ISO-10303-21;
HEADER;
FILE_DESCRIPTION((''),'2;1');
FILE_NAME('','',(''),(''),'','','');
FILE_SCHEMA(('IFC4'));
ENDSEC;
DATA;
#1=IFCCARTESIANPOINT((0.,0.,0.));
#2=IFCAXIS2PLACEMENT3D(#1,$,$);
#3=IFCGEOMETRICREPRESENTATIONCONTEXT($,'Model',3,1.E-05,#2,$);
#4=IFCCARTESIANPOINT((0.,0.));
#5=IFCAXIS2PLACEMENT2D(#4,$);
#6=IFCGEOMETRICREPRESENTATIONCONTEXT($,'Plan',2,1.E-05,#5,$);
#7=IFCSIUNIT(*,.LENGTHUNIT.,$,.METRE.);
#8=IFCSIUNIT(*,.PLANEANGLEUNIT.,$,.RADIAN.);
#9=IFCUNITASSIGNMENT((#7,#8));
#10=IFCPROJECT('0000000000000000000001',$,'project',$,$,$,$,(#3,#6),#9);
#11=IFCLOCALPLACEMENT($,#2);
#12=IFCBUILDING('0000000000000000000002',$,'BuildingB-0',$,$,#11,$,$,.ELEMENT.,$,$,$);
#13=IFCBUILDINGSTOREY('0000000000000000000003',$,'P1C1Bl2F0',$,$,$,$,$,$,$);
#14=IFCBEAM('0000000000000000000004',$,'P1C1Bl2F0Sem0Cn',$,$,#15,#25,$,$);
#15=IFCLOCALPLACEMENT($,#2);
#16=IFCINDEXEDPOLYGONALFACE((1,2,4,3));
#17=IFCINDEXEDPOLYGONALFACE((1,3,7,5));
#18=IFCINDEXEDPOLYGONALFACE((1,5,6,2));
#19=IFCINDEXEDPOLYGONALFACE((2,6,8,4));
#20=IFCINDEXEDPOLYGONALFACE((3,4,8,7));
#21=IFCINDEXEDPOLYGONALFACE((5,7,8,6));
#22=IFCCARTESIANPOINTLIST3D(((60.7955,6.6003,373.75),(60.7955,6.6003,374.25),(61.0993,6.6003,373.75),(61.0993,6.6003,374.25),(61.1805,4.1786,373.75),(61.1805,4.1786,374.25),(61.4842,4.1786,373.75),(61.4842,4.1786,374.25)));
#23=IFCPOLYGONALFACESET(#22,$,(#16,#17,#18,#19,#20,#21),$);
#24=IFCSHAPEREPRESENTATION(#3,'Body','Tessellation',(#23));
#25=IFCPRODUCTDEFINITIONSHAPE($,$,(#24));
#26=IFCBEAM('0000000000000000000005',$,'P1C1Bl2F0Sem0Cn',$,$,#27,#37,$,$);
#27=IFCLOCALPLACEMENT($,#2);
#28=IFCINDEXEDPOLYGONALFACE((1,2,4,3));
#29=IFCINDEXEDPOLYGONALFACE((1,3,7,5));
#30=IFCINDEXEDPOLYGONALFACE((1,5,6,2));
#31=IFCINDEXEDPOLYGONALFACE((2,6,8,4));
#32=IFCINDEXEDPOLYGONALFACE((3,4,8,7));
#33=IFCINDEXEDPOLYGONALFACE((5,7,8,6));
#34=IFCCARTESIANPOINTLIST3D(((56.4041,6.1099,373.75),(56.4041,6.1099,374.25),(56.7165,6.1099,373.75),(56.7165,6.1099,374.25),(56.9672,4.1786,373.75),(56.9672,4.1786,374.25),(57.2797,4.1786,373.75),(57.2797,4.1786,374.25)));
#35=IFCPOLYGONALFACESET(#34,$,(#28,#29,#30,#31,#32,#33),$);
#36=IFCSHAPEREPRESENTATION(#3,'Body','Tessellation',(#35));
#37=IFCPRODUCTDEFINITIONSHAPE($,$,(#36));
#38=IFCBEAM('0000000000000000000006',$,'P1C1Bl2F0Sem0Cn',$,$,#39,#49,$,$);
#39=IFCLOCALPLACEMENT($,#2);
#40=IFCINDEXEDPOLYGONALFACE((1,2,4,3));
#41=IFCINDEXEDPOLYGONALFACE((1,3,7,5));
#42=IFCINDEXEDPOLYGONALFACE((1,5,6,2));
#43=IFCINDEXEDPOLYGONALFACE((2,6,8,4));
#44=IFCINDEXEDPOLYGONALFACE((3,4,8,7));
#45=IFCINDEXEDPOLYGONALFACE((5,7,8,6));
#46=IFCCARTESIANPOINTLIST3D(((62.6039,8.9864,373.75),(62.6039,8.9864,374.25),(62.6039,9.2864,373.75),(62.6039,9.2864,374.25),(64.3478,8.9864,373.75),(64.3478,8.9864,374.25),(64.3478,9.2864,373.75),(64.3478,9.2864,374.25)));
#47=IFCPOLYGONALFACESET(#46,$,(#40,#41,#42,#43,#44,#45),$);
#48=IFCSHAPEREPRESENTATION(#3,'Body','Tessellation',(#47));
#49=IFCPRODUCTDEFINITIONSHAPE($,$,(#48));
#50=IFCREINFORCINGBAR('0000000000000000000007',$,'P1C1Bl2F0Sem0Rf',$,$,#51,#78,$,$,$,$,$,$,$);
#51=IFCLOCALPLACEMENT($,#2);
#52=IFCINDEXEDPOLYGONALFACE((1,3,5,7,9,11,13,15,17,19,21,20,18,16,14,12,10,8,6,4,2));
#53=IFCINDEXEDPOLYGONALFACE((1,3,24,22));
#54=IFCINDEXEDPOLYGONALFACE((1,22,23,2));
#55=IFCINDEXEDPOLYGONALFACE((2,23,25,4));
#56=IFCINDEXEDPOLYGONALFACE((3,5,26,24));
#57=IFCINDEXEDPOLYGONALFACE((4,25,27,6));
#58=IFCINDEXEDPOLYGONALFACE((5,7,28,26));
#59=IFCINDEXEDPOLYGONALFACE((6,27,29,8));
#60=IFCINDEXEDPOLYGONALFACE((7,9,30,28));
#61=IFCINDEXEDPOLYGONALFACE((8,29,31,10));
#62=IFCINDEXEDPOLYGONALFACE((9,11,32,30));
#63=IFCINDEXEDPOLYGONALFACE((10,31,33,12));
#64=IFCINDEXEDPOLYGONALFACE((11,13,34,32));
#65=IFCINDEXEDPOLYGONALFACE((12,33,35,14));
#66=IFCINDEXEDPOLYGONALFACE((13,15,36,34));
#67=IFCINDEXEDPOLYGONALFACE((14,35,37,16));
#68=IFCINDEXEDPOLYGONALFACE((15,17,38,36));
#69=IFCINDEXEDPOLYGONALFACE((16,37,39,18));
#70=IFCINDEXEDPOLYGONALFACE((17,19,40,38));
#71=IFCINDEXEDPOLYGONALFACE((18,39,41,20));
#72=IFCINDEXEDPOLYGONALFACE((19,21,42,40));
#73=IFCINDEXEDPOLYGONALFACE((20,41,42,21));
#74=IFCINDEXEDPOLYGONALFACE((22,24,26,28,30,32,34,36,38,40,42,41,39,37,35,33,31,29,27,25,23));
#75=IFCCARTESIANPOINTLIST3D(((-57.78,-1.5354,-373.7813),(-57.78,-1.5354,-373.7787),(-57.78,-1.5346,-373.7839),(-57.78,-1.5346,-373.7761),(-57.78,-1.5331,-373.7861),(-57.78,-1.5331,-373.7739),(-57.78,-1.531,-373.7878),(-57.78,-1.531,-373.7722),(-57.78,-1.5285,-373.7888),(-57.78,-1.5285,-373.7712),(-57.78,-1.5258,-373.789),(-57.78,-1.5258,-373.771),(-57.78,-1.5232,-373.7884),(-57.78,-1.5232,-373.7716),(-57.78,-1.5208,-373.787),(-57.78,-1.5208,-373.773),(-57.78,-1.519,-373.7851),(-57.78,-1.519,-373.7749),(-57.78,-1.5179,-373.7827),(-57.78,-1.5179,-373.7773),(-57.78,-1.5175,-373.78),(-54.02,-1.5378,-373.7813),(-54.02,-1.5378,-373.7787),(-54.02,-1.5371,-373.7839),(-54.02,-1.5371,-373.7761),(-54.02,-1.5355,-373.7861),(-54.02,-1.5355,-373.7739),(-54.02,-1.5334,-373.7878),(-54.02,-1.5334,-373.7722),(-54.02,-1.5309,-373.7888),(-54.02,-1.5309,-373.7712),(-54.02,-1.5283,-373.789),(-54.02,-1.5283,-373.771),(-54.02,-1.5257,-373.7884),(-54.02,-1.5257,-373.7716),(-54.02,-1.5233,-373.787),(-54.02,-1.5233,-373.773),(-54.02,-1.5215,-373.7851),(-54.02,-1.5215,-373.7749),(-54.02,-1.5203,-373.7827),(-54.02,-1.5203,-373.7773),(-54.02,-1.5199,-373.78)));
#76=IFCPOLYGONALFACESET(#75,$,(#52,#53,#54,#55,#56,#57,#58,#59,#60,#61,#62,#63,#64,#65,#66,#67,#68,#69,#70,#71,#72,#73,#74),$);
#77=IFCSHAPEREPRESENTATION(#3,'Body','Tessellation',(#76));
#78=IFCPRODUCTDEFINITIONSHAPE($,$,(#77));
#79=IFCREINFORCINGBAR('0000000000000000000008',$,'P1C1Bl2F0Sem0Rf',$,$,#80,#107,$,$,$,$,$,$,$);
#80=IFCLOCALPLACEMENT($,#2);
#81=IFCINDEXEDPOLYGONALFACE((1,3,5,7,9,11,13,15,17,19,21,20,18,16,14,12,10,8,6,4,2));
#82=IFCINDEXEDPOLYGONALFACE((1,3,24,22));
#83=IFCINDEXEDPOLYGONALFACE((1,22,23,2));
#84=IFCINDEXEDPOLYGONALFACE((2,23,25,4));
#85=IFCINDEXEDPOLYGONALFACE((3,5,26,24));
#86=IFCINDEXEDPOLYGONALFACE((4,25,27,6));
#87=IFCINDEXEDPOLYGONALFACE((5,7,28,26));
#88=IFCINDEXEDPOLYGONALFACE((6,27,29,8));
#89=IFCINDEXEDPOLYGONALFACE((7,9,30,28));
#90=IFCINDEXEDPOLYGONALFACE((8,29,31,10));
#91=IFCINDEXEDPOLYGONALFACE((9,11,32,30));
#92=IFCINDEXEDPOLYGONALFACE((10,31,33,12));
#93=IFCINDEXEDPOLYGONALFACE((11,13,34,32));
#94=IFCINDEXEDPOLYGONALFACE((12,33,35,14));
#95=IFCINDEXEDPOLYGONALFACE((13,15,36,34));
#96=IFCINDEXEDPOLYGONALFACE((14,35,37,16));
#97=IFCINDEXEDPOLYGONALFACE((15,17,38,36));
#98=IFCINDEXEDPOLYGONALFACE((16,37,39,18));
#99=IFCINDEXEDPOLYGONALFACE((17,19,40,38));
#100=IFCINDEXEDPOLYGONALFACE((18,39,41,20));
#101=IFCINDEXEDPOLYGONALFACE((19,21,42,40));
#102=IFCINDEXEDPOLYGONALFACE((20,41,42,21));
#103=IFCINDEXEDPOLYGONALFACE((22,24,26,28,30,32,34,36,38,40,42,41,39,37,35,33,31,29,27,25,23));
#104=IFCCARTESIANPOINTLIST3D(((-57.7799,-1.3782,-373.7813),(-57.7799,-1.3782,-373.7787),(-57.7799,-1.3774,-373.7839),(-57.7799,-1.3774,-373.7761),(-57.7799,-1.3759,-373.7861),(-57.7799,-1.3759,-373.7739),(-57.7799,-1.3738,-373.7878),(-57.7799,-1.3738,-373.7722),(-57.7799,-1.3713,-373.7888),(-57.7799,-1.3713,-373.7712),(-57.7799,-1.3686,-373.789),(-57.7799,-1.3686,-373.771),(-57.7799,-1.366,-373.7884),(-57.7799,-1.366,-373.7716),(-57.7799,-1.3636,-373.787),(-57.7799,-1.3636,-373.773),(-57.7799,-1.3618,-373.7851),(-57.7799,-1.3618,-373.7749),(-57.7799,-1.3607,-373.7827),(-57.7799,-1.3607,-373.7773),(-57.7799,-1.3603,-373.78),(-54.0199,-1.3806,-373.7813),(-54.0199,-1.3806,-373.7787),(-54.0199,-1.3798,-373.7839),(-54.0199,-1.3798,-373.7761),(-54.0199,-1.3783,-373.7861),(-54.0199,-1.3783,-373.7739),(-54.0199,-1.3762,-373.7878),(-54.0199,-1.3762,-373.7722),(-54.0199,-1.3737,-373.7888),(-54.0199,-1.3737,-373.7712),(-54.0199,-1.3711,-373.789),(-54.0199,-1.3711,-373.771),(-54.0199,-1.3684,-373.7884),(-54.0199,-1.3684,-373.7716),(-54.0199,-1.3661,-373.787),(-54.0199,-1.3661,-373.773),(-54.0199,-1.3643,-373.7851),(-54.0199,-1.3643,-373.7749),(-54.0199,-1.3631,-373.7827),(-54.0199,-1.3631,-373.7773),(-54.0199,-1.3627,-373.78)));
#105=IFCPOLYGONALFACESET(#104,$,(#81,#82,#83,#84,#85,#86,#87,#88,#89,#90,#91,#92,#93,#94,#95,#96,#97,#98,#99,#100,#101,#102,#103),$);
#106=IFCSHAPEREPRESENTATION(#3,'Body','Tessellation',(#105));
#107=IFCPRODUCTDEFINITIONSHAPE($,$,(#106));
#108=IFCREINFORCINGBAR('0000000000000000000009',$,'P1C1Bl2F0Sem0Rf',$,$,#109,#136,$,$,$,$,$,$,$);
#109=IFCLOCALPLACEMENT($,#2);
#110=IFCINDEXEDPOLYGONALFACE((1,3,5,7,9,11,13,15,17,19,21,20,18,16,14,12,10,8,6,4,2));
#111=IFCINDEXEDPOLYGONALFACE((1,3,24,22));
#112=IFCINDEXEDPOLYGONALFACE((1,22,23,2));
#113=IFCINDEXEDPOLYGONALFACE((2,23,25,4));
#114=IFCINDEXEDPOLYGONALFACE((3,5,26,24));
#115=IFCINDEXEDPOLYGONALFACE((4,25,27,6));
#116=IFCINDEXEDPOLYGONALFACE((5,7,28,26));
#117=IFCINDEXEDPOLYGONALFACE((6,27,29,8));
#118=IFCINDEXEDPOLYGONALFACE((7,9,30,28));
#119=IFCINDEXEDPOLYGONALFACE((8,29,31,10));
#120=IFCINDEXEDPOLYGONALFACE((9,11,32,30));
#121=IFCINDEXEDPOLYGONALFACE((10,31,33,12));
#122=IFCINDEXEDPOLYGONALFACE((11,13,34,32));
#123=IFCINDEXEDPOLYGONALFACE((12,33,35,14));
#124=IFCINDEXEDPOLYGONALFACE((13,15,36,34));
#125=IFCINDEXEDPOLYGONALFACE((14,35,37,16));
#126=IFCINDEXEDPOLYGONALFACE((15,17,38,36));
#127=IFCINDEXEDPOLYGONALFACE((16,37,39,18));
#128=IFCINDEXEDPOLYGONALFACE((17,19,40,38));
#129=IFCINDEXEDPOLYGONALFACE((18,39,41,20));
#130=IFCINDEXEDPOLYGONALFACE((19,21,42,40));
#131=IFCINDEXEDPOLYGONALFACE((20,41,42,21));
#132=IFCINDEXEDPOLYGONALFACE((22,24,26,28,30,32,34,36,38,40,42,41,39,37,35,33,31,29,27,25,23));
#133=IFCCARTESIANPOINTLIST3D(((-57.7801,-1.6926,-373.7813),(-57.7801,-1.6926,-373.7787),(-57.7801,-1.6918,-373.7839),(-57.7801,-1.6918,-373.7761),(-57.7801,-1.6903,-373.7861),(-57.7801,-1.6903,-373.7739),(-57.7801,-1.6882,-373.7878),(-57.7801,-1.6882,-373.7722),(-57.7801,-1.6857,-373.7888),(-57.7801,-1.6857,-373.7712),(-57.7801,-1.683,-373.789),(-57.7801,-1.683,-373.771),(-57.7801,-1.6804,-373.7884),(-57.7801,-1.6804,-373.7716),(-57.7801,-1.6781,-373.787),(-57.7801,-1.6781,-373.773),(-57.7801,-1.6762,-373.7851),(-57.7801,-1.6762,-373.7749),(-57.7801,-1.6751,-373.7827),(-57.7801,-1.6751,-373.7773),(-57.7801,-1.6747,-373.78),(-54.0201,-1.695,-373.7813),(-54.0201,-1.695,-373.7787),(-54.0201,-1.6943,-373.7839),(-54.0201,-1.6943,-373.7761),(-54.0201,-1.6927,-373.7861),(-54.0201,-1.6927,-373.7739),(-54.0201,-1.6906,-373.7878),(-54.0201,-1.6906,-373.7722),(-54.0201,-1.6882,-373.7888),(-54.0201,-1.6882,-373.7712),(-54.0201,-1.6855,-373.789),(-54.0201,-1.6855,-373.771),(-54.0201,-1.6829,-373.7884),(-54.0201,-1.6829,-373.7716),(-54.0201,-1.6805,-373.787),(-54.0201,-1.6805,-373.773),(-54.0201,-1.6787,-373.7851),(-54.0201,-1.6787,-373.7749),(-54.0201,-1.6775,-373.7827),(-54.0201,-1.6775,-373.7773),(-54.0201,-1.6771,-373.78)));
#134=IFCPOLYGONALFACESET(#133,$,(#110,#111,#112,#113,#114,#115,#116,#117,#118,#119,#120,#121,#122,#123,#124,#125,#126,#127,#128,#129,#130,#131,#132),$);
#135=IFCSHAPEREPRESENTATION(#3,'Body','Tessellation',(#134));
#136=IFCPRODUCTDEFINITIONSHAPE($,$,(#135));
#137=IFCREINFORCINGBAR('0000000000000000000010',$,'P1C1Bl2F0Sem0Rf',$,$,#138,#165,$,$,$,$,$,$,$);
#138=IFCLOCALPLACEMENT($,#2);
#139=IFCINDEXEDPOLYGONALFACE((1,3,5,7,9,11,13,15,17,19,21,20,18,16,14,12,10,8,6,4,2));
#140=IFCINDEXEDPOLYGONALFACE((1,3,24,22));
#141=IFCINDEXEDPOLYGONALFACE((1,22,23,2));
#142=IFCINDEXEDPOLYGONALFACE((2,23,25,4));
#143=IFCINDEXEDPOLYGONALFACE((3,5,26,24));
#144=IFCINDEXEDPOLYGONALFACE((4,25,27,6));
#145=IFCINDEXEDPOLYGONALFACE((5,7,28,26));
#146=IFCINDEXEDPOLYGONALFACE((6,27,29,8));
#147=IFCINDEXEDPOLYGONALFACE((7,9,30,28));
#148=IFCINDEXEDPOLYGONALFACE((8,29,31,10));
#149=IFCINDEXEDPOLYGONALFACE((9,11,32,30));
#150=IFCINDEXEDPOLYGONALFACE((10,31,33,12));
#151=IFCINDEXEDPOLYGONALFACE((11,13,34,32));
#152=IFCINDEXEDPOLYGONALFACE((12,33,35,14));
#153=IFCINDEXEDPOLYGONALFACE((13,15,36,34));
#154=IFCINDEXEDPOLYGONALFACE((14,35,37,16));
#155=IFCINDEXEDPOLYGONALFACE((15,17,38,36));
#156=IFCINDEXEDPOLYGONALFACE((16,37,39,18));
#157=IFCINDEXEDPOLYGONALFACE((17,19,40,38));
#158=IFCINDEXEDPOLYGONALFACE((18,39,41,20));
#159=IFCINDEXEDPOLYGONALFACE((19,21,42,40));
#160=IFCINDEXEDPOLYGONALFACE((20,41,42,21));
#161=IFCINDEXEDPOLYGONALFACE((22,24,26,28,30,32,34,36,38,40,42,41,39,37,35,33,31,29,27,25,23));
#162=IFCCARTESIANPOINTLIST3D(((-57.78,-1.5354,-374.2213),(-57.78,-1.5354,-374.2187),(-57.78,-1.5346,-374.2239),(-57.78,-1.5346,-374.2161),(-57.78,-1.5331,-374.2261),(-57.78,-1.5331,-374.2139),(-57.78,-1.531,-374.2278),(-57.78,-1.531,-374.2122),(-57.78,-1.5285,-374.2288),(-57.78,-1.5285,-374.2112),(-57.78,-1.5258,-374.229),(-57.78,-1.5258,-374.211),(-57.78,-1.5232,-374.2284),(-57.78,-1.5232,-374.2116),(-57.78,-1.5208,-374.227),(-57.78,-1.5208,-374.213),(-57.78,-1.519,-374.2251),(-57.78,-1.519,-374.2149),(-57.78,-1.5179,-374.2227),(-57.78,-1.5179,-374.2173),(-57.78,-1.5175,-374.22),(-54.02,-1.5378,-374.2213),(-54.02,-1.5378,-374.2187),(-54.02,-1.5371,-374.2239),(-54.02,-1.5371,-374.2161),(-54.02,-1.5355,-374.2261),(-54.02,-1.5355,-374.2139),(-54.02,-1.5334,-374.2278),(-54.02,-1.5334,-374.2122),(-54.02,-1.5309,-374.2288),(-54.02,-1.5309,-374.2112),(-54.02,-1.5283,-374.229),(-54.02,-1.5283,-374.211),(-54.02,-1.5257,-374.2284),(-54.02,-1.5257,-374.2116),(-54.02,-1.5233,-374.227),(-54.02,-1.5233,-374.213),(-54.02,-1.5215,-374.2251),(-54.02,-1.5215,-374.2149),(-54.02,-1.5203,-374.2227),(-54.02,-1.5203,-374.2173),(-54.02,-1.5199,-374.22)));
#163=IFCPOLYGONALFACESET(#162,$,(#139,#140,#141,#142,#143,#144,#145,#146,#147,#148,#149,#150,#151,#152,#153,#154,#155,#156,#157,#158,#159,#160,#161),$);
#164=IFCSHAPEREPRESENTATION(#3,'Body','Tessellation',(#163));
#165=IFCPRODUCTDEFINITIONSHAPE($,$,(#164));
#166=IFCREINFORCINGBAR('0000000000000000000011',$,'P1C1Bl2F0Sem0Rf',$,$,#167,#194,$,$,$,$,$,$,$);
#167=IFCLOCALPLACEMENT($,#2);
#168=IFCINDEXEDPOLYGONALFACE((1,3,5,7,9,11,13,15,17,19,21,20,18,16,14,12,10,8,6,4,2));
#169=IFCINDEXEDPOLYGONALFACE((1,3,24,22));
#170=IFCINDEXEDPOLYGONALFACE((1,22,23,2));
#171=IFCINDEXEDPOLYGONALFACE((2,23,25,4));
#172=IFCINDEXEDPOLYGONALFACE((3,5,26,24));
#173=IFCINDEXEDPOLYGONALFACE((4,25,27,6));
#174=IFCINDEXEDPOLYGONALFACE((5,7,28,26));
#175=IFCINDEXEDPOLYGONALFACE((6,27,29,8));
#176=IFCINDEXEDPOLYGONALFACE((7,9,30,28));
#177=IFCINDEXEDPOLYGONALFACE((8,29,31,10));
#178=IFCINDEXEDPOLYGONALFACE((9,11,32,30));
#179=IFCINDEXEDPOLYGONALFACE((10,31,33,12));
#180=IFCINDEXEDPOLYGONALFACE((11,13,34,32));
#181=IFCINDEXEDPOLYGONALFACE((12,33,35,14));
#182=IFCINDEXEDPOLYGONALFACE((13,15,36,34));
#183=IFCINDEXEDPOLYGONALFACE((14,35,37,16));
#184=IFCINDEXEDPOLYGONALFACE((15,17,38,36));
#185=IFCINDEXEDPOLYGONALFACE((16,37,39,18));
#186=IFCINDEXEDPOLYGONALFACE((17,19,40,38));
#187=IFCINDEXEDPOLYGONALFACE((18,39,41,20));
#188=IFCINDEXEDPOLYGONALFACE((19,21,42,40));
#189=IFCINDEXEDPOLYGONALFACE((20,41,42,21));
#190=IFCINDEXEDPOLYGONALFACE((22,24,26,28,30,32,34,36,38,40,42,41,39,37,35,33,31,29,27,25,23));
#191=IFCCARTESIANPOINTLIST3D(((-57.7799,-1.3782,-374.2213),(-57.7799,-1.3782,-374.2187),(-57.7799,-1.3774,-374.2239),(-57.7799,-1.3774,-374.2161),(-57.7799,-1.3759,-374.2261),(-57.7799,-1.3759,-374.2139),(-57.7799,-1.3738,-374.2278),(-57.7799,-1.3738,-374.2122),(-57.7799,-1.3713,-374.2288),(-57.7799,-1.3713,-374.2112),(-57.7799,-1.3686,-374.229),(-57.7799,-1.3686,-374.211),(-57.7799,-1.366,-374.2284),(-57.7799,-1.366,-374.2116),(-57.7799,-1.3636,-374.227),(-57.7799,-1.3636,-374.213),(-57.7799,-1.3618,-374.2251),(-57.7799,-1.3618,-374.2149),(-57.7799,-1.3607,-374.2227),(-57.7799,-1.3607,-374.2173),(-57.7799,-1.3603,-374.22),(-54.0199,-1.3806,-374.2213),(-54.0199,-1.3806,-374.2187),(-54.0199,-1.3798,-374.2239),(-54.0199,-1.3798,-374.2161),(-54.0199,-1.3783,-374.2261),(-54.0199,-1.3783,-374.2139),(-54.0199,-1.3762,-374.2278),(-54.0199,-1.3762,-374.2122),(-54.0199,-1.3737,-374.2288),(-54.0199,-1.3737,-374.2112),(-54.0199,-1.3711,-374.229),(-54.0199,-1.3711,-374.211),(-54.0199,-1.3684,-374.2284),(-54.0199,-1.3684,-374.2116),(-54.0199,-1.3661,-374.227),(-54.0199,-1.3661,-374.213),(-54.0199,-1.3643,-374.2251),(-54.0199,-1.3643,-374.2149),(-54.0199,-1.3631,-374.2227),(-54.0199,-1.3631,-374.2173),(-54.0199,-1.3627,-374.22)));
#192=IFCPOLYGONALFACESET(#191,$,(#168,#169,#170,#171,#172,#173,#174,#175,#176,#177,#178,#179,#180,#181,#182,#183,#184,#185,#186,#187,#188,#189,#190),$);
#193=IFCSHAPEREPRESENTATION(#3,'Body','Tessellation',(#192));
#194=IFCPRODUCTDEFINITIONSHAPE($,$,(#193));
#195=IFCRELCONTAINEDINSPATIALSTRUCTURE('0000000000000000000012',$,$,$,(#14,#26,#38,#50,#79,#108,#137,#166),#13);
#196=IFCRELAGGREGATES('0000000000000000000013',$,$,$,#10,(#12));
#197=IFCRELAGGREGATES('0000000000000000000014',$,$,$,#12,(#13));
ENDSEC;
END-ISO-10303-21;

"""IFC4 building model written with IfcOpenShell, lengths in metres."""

from ifc_helpers import new_model, entity, si_unit, origin, origin_2d, place, context, project, spatial, polyline, outline, extrude, element, save


model = new_model("IFC4")

# Units and contexts
model_context = context("Model", 3, precision=1e-05, world=origin())
plan_context = context("Plan", 2, precision=1e-05, world=origin_2d())
ifc_project = project(units=[si_unit("LENGTHUNIT", "METRE"), si_unit("PLANEANGLEUNIT", "RADIAN")], contexts=[model_context, plan_context])

# Building, storey
building_placement = place(None, origin())
building = spatial("IfcBuilding", under=ifc_project, at=building_placement, Name="BuildingB-0", CompositionType="ELEMENT")
storey = spatial("IfcBuildingStorey", under=building, Name="P1C1Bl2F0")

# Beams
element("IfcBeam", 1, inside=storey, Name="P1C1Bl2F0Sem0Cn", context=model_context, shape_type="SweptSolid", body=[
    extrude(outline(polyline([(61.4842, 4.1786, 373.75), (61.0993, 6.6003, 373.75), (60.7955, 6.6003, 373.75), (61.1805, 4.1786, 373.75), (61.4842, 4.1786, 373.75)])), None, (0.0, 0.0, 1.0), 0.5),
])
element("IfcBeam", 2, inside=storey, Name="P1C1Bl2F0Sem0Cn", context=model_context, shape_type="SweptSolid", body=[
    extrude(outline(polyline([(56.9672, 4.1786, 373.75), (57.2797, 4.1786, 373.75), (56.7165, 6.1099, 373.75), (56.4041, 6.1099, 373.75), (56.9672, 4.1786, 373.75)])), None, (0.0, 0.0, 1.0), 0.5),
])
element("IfcBeam", 3, inside=storey, Name="P1C1Bl2F0Sem0Cn", context=model_context, shape_type="SweptSolid", body=[
    extrude(outline(polyline([(64.3478, 8.9864, 373.75), (62.6039, 8.9864, 373.75), (62.6039, 9.2864, 373.75), (64.3478, 9.2864, 373.75), (64.3478, 8.9864, 373.75)])), None, (0.0, 0.0, 1.0), 0.5),
])

# Reinforcing bars
element("IfcReinforcingBar", 4, inside=storey, Name="P1C1Bl2F0Sem0Rf", context=model_context, shape_type="SweptSolid", body=[
    entity("IfcSurfaceCurveSweptAreaSolid", entity("IfcCircleProfileDef", "AREA", None, None, 0.009), None, entity("IfcPolyline", [entity("IfcCartesianPoint", [54.02, 1.5289, 373.78]), entity("IfcCartesianPoint", [57.78, 1.5265, 373.78])]), None, None, entity("IfcPlane", entity("IfcAxis2Placement3D", entity("IfcCartesianPoint", [54.02, 1.5289, 373.78]), entity("IfcDirection", [0.0, 0.0, 1.0]), entity("IfcDirection", [1.0, 0.0, 0.0])))),
])
element("IfcReinforcingBar", 5, inside=storey, Name="P1C1Bl2F0Sem0Rf", context=model_context, shape_type="SweptSolid", body=[
    entity("IfcSurfaceCurveSweptAreaSolid", entity("IfcCircleProfileDef", "AREA", None, None, 0.009), None, entity("IfcPolyline", [entity("IfcCartesianPoint", [54.0199, 1.3717, 373.78]), entity("IfcCartesianPoint", [57.7799, 1.3693, 373.78])]), None, None, entity("IfcPlane", entity("IfcAxis2Placement3D", entity("IfcCartesianPoint", [54.0199, 1.3717, 373.78]), entity("IfcDirection", [0.0, 0.0, 1.0]), entity("IfcDirection", [1.0, 0.0, 0.0])))),
])
element("IfcReinforcingBar", 6, inside=storey, Name="P1C1Bl2F0Sem0Rf", context=model_context, shape_type="SweptSolid", body=[
    entity("IfcSurfaceCurveSweptAreaSolid", entity("IfcCircleProfileDef", "AREA", None, None, 0.009), None, entity("IfcPolyline", [entity("IfcCartesianPoint", [54.0201, 1.6861, 373.78]), entity("IfcCartesianPoint", [57.7801, 1.6837, 373.78])]), None, None, entity("IfcPlane", entity("IfcAxis2Placement3D", entity("IfcCartesianPoint", [54.0201, 1.6861, 373.78]), entity("IfcDirection", [0.0, 0.0, 1.0]), entity("IfcDirection", [1.0, 0.0, 0.0])))),
])
element("IfcReinforcingBar", 7, inside=storey, Name="P1C1Bl2F0Sem0Rf", context=model_context, shape_type="SweptSolid", body=[
    entity("IfcSurfaceCurveSweptAreaSolid", entity("IfcCircleProfileDef", "AREA", None, None, 0.009), None, entity("IfcPolyline", [entity("IfcCartesianPoint", [54.02, 1.5289, 374.22]), entity("IfcCartesianPoint", [57.78, 1.5265, 374.22])]), None, None, entity("IfcPlane", entity("IfcAxis2Placement3D", entity("IfcCartesianPoint", [54.02, 1.5289, 374.22]), entity("IfcDirection", [0.0, 0.0, 1.0]), entity("IfcDirection", [1.0, 0.0, 0.0])))),
])
element("IfcReinforcingBar", 8, inside=storey, Name="P1C1Bl2F0Sem0Rf", context=model_context, shape_type="SweptSolid", body=[
    entity("IfcSurfaceCurveSweptAreaSolid", entity("IfcCircleProfileDef", "AREA", None, None, 0.009), None, entity("IfcPolyline", [entity("IfcCartesianPoint", [54.0199, 1.3717, 374.22]), entity("IfcCartesianPoint", [57.7799, 1.3693, 374.22])]), None, None, entity("IfcPlane", entity("IfcAxis2Placement3D", entity("IfcCartesianPoint", [54.0199, 1.3717, 374.22]), entity("IfcDirection", [0.0, 0.0, 1.0]), entity("IfcDirection", [1.0, 0.0, 0.0])))),
])

save(model, "model.ifc")
